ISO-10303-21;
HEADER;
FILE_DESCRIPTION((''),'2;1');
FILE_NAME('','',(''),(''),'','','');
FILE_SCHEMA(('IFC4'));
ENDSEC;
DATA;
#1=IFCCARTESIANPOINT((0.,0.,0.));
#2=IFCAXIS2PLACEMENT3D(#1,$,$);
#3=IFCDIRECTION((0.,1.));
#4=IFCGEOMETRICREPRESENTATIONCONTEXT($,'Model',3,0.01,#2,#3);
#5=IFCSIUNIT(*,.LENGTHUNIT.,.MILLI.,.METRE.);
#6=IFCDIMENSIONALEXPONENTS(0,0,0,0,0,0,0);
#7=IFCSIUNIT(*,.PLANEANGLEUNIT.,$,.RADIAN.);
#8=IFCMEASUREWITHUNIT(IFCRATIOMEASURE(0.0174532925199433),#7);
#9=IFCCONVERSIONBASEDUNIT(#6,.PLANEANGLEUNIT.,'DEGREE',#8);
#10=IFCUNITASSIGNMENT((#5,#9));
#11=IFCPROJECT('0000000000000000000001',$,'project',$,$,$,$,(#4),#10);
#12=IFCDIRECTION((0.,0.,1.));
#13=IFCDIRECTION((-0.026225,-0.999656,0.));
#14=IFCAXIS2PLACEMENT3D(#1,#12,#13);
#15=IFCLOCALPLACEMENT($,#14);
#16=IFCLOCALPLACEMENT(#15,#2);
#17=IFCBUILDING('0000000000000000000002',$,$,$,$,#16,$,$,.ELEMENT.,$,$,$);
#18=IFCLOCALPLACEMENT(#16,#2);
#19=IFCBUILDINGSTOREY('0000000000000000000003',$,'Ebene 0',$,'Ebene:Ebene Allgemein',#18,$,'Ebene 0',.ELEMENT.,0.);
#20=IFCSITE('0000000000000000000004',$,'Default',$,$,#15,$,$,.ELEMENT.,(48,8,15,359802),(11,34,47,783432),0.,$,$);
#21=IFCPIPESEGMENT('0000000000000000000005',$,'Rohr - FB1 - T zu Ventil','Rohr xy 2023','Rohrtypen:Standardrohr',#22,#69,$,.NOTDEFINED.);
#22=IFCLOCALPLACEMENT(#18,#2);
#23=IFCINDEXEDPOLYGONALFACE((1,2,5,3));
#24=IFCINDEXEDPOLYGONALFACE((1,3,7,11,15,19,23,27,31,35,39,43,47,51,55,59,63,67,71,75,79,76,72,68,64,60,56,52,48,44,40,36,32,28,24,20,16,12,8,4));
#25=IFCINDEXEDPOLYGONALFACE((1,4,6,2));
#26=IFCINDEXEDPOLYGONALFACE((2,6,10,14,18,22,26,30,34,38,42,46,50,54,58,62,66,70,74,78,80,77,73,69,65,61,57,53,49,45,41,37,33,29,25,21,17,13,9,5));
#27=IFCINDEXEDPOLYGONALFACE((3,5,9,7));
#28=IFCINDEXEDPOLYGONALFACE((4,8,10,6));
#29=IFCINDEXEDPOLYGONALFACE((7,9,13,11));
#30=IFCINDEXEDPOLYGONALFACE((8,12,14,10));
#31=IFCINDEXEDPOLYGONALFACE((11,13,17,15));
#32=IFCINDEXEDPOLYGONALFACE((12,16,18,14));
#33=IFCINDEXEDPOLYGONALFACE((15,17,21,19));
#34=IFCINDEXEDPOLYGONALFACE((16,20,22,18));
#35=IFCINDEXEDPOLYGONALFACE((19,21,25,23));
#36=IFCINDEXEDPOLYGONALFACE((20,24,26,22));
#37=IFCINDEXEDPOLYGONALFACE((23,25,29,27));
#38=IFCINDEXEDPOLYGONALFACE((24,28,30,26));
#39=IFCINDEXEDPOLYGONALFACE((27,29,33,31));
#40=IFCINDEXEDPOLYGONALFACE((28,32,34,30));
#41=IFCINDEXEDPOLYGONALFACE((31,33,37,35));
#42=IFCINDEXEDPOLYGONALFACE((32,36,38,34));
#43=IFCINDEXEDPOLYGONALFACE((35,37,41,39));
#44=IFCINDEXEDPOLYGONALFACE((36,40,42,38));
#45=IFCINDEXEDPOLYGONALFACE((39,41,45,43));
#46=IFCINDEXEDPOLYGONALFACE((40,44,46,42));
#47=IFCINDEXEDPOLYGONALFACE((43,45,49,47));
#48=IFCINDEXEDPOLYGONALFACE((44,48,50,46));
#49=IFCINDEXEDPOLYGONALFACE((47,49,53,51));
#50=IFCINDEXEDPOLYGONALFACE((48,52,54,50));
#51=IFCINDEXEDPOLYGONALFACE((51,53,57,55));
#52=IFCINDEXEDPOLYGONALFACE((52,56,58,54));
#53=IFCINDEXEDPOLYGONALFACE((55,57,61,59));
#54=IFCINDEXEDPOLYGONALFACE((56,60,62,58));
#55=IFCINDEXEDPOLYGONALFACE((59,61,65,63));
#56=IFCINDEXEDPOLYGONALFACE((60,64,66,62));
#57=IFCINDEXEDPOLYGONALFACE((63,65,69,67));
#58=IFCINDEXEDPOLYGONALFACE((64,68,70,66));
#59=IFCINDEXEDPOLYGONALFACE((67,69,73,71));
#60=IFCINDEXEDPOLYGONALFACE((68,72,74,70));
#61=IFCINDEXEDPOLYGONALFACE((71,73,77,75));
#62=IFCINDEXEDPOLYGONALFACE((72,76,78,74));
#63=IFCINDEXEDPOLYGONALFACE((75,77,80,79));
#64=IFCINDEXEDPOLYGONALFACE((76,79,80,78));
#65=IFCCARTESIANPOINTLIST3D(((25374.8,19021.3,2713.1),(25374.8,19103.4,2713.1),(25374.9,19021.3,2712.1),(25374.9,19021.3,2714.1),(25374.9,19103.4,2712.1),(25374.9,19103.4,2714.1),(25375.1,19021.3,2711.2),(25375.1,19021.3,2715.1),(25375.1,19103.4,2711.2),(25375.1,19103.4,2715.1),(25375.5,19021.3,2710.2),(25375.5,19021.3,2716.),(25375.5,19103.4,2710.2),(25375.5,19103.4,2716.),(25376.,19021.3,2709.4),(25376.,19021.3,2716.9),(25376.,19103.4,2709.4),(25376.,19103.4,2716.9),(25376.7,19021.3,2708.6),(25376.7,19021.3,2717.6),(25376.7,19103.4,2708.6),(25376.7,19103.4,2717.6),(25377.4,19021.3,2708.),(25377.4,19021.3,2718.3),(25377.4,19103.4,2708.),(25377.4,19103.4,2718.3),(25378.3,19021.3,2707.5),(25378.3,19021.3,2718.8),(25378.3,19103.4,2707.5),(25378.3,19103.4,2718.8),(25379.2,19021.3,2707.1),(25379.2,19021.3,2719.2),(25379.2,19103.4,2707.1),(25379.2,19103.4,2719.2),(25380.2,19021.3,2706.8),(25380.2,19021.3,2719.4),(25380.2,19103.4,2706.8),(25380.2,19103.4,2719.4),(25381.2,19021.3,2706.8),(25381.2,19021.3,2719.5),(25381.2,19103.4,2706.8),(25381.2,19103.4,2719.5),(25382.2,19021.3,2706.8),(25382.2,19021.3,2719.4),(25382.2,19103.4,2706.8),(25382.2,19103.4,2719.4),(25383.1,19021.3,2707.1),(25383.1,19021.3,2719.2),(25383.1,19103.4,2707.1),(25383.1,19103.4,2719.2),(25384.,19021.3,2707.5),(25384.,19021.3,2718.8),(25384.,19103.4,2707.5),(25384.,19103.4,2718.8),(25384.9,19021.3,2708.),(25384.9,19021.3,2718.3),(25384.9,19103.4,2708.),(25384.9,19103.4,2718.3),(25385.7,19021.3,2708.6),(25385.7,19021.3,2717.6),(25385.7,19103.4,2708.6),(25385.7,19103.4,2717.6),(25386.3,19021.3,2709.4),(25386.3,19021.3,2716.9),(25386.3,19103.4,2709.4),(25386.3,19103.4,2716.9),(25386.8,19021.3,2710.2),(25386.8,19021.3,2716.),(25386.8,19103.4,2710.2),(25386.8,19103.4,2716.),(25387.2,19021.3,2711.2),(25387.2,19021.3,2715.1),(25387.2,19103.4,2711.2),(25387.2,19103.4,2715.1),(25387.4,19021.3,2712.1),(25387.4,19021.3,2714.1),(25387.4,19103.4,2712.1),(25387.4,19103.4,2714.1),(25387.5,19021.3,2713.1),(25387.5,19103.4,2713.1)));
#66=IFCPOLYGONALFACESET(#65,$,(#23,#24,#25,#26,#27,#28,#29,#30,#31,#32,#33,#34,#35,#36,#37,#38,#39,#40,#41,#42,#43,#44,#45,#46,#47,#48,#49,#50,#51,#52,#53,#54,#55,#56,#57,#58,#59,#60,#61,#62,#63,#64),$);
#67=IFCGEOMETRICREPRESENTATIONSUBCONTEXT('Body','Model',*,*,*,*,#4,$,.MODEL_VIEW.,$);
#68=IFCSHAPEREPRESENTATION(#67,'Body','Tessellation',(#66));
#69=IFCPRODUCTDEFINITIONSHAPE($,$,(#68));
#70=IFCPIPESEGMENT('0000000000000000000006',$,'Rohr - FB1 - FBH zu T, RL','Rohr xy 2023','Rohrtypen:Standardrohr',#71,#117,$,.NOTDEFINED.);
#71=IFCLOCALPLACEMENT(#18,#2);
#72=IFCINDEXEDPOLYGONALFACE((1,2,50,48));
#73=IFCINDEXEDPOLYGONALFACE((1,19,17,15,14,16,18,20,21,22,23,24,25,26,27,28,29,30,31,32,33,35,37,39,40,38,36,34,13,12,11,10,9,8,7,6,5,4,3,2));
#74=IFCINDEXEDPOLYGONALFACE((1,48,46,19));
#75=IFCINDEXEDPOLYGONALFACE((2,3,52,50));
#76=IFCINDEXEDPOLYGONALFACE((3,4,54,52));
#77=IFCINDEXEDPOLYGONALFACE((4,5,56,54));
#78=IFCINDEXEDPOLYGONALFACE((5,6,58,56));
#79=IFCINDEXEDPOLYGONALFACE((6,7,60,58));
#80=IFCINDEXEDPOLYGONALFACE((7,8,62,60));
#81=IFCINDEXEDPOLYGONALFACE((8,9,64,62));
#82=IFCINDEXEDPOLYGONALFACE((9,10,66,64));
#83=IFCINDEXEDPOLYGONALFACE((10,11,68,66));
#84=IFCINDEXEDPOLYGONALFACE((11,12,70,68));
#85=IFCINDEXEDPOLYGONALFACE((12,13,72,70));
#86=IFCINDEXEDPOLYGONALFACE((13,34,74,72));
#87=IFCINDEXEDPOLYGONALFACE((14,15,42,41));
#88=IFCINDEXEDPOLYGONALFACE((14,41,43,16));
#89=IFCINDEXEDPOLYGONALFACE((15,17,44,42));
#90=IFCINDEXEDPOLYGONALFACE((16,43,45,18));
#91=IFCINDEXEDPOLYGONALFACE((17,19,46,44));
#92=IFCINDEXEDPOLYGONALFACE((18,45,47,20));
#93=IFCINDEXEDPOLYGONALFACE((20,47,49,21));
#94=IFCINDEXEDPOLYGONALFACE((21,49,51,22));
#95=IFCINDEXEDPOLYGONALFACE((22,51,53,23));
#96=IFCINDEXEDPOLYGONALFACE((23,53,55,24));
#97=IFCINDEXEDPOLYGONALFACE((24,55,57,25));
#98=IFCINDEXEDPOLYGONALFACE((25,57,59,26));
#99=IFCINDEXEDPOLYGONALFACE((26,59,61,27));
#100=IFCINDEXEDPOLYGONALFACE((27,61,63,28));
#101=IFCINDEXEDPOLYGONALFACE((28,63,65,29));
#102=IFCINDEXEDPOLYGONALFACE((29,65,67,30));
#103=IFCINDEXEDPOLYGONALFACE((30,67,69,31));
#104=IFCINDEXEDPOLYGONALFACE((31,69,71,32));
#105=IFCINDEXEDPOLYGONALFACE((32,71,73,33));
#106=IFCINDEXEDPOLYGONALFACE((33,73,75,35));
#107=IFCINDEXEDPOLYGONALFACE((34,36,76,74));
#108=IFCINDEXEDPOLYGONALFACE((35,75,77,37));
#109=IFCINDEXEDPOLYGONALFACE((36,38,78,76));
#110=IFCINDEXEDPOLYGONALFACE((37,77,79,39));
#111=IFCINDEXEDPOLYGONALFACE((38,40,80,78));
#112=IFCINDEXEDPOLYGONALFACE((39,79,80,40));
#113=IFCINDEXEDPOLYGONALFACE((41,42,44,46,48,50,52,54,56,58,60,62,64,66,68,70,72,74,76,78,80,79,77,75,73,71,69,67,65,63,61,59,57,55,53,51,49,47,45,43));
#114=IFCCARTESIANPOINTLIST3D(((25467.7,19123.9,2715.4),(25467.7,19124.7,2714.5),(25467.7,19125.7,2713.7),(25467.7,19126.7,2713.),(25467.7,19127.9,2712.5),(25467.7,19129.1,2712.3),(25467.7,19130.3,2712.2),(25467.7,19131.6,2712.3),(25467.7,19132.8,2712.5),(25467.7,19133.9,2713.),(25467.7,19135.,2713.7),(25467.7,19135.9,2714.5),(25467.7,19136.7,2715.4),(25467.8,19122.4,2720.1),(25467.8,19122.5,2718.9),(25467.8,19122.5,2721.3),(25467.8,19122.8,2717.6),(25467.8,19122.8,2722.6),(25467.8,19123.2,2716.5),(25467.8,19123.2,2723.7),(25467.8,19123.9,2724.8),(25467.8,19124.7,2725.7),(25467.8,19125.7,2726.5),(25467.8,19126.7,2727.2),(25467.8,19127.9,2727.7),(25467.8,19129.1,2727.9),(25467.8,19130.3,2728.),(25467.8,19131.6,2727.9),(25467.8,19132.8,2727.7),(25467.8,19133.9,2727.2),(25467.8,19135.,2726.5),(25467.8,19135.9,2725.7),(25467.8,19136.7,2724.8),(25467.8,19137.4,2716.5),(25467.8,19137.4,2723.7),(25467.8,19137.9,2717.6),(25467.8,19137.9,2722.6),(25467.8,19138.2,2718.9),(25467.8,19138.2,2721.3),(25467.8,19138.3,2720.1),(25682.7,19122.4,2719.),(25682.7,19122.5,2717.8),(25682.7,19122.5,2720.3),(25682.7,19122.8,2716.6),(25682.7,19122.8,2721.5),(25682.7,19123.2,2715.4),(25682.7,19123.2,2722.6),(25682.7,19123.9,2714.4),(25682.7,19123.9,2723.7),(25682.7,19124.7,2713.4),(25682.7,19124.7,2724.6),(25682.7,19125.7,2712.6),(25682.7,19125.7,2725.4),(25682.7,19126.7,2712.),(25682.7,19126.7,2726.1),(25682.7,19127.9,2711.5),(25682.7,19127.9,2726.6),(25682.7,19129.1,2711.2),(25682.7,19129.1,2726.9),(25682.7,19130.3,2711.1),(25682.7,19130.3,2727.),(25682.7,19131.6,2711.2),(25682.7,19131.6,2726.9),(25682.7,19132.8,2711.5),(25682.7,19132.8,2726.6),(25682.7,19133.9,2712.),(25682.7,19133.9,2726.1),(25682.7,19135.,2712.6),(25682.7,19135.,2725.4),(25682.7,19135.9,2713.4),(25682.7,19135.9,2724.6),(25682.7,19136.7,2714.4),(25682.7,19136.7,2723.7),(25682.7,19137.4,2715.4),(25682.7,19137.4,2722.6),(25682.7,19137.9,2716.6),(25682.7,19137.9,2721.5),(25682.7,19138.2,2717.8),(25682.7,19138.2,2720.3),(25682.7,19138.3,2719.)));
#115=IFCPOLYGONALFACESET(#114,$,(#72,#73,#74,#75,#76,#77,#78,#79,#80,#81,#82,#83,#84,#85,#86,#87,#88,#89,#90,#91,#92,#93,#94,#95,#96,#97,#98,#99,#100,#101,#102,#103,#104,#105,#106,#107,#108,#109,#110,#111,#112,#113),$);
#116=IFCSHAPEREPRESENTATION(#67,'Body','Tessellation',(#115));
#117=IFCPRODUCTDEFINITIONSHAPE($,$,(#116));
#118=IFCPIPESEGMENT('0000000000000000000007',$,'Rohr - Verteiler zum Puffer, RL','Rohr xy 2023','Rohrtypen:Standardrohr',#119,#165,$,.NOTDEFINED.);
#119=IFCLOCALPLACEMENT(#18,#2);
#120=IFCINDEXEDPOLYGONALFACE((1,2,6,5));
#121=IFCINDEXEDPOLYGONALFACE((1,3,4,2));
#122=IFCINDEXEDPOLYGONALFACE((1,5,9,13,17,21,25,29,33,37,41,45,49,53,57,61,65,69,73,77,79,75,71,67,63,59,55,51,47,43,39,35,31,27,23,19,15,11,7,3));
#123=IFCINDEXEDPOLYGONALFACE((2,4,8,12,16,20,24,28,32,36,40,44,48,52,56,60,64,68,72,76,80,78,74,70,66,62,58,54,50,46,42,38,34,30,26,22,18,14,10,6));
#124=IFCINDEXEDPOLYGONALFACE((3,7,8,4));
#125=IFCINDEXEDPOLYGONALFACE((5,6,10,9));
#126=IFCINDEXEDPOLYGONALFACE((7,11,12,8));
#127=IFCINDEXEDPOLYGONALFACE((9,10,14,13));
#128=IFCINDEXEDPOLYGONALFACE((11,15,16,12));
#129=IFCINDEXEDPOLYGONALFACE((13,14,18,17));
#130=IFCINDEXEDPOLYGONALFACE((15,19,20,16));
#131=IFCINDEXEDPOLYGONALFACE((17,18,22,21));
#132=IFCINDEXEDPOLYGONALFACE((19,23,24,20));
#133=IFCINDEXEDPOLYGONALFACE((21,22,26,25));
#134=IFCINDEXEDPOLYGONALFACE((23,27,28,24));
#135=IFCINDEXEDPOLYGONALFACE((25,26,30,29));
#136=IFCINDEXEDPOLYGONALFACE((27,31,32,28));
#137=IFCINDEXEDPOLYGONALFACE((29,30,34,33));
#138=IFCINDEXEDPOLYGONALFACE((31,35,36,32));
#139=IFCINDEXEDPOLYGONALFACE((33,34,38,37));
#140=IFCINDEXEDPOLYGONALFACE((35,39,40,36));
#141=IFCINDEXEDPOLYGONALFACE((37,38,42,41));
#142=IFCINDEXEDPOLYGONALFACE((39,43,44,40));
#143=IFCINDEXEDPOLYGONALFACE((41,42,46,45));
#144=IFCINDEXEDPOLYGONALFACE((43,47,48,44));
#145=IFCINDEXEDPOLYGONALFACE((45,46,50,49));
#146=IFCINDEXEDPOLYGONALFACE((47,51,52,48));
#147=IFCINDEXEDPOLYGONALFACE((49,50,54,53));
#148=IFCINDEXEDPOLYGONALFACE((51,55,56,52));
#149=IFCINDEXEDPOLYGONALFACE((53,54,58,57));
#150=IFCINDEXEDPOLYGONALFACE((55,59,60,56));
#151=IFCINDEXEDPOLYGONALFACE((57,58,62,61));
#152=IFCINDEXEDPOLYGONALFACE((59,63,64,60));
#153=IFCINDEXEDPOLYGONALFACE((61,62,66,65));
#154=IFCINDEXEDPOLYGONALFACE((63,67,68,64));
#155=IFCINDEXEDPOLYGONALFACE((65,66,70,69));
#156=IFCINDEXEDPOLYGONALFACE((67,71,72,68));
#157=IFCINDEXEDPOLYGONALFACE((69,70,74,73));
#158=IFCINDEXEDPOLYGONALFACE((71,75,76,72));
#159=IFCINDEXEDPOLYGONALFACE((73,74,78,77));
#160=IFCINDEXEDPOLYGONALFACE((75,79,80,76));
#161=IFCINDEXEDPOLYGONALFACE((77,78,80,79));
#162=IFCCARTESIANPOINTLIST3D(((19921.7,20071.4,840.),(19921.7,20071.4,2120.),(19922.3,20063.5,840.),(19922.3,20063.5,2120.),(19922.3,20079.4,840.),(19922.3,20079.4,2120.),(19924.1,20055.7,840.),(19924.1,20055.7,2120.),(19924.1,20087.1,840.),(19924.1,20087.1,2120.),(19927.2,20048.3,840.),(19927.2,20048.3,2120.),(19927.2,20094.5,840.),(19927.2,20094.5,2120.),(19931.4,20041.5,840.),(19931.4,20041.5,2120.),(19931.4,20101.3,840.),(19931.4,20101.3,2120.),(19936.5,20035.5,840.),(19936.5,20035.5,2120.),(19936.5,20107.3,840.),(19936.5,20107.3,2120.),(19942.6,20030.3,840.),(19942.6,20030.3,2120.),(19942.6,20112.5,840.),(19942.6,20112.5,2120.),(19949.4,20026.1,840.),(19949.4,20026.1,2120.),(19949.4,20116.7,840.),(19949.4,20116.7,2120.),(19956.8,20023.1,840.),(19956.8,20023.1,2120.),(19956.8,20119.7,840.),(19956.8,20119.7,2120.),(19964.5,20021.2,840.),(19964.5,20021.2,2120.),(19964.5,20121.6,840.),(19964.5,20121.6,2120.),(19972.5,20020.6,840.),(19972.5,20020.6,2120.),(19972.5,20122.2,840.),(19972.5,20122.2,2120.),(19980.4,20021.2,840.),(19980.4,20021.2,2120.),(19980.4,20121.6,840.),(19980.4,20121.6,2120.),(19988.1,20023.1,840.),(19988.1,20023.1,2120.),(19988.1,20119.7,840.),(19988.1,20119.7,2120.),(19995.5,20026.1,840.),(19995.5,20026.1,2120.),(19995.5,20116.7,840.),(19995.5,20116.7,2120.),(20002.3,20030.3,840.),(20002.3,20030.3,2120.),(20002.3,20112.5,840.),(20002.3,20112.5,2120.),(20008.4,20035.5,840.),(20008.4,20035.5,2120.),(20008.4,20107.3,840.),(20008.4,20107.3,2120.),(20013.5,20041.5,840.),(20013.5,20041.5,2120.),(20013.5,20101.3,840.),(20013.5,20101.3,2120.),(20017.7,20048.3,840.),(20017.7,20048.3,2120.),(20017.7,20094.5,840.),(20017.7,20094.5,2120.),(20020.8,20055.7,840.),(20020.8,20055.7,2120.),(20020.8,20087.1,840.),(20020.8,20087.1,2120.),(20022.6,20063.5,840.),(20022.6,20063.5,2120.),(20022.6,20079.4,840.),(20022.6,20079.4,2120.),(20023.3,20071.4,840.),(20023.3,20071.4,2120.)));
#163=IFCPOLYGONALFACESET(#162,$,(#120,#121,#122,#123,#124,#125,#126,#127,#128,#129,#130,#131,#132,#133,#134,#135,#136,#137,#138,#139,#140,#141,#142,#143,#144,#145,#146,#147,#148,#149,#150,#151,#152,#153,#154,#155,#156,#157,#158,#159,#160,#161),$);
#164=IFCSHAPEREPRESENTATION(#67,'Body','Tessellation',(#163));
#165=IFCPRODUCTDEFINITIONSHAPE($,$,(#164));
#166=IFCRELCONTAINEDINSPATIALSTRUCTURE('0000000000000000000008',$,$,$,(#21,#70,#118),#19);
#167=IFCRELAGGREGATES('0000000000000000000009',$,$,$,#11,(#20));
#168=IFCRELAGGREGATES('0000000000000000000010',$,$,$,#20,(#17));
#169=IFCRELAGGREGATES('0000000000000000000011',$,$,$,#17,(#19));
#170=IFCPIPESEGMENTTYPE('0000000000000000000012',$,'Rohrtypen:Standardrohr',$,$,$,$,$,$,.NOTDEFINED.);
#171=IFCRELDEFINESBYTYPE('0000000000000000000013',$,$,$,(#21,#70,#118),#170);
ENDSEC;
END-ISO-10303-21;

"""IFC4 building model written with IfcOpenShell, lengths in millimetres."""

from ifc_helpers import new_model, entity, si_unit, converted_unit, direction, frame, origin, place, context, subcontext, project, spatial, indexed_curve, outline, extrude, type_object, element, save


model = new_model("IFC4")

# Units and contexts
model_context = context("Model", 3, precision=0.01, world=origin(), true_north=direction((0.0, 1.0)))
body_context = subcontext(model_context, "Body", "Model", "MODEL_VIEW")
ifc_project = project(units=[si_unit("LENGTHUNIT", "METRE", prefix="MILLI"), converted_unit("PLANEANGLEUNIT", "DEGREE", entity("IfcRatioMeasure", 0.0174532925199433), si_unit("PLANEANGLEUNIT", "RADIAN"), dimensions=[0, 0, 0, 0, 0, 0, 0])], contexts=[model_context])

# Site, building, storey
site_placement = place(None, frame((0.0, 0.0, 0.0), z_axis=(0.0, 0.0, 1.0), x_axis=(-0.026225, -0.999656, 0.0)))
site = spatial("IfcSite", under=ifc_project, at=site_placement, Name="Default", CompositionType="ELEMENT", RefLatitude=(48, 8, 15, 359802), RefLongitude=(11, 34, 47, 783432), RefElevation=0.0)
building_placement = place(site_placement, origin())
building = spatial("IfcBuilding", under=site, at=building_placement, CompositionType="ELEMENT")
storey_placement = place(building_placement, origin())
storey = spatial("IfcBuildingStorey", under=building, at=storey_placement, Name="Ebene 0", ObjectType="Ebene:Ebene Allgemein", LongName="Ebene 0", CompositionType="ELEMENT", Elevation=0.0)

# Pipe segments
pipe_segment_type = type_object("IfcPipeSegmentType", Name="Rohrtypen:Standardrohr", PredefinedType="NOTDEFINED")
pipe_segment_1_placement = place(storey_placement, origin())
element("IfcPipeSegment", 1, at=pipe_segment_1_placement, inside=storey, type_object=pipe_segment_type, Name="Rohr - FB1 - T zu Ventil", Description="Rohr xy 2023", ObjectType="Rohrtypen:Standardrohr", PredefinedType="NOTDEFINED", context=body_context, shape_type="SweptSolid", body=[
    extrude(outline(indexed_curve([(6.3, 0.0), (6.3, 1.0), (6.0, 2.0), (5.7, 2.9), (5.1, 3.7), (4.5, 4.5), (3.7, 5.1), (2.9, 5.7), (2.0, 6.0), (1.0, 6.3), (0.0, 6.4), (-1.0, 6.3), (-2.0, 6.0), (-2.9, 5.7), (-3.7, 5.1), (-4.5, 4.5), (-5.1, 3.7), (-5.7, 2.9), (-6.0, 2.0), (-6.3, 1.0), (-6.3, 0.0), (-6.3, -1.0), (-6.0, -2.0), (-5.7, -2.9), (-5.1, -3.7), (-4.5, -4.5), (-3.7, -5.1), (-2.9, -5.7), (-2.0, -6.0), (-1.0, -6.3), (0.0, -6.4), (1.0, -6.3), (2.0, -6.0), (2.9, -5.7), (3.7, -5.1), (4.5, -4.5), (5.1, -3.7), (5.7, -2.9), (6.0, -2.0), (6.3, -1.0), (6.3, 0.0)], self_intersect=False)), frame((25381.2, 19021.3, 2713.1), z_axis=(0.0, 1.0, 0.0), x_axis=(-1.0, 0.0, 0.0)), (0.0, 0.0, 1.0), 82.2),
])
pipe_segment_2_placement = place(storey_placement, origin())
element("IfcPipeSegment", 2, at=pipe_segment_2_placement, inside=storey, type_object=pipe_segment_type, Name="Rohr - FB1 - FBH zu T, RL", Description="Rohr xy 2023", ObjectType="Rohrtypen:Standardrohr", PredefinedType="NOTDEFINED", context=body_context, shape_type="SweptSolid", body=[
    extrude(outline(indexed_curve([(7.9, 0.0), (7.8, 1.2), (7.6, 2.5), (7.1, 3.6), (6.4, 4.7), (5.6, 5.6), (4.7, 6.4), (3.6, 7.1), (2.5, 7.6), (1.2, 7.8), (0.0, 7.9), (-1.2, 7.8), (-2.5, 7.6), (-3.6, 7.1), (-4.7, 6.4), (-5.6, 5.6), (-6.4, 4.7), (-7.1, 3.6), (-7.6, 2.5), (-7.8, 1.2), (-7.9, 0.0), (-7.8, -1.2), (-7.6, -2.5), (-7.1, -3.6), (-6.4, -4.7), (-5.6, -5.6), (-4.7, -6.4), (-3.6, -7.1), (-2.5, -7.6), (-1.2, -7.8), (0.0, -7.9), (1.2, -7.8), (2.5, -7.6), (3.6, -7.1), (4.7, -6.4), (5.6, -5.6), (6.4, -4.7), (7.1, -3.6), (7.6, -2.5), (7.8, -1.2), (7.9, 0.0)], self_intersect=False)), frame((25682.7, 19130.3, 2719.0), z_axis=(-0.999988, 0.0, 0.005), x_axis=(0.0, 1.0, 0.0)), (0.0, 0.0, 1.0), 214.9),
])
pipe_segment_3_placement = place(storey_placement, origin())
element("IfcPipeSegment", 3, at=pipe_segment_3_placement, inside=storey, type_object=pipe_segment_type, Name="Rohr - Verteiler zum Puffer, RL", Description="Rohr xy 2023", ObjectType="Rohrtypen:Standardrohr", PredefinedType="NOTDEFINED", context=body_context, shape_type="SweptSolid", body=[
    extrude(outline(indexed_curve([(50.8, 0.0), (50.2, 7.9), (48.3, 15.7), (45.3, 23.1), (41.1, 29.9), (35.9, 35.9), (29.9, 41.1), (23.1, 45.3), (15.7, 48.3), (7.9, 50.2), (0.0, 50.8), (-7.9, 50.2), (-15.7, 48.3), (-23.1, 45.3), (-29.9, 41.1), (-35.9, 35.9), (-41.1, 29.9), (-45.3, 23.1), (-48.3, 15.7), (-50.2, 7.9), (-50.8, 0.0), (-50.2, -7.9), (-48.3, -15.7), (-45.3, -23.1), (-41.1, -29.9), (-35.9, -35.9), (-29.9, -41.1), (-23.1, -45.3), (-15.7, -48.3), (-7.9, -50.2), (0.0, -50.8), (7.9, -50.2), (15.7, -48.3), (23.1, -45.3), (29.9, -41.1), (35.9, -35.9), (41.1, -29.9), (45.3, -23.1), (48.3, -15.7), (50.2, -7.9), (50.8, 0.0)], self_intersect=False)), frame((19972.5, 20071.4, 840.0), z_axis=(0.0, 0.0, 1.0), x_axis=(-1.0, 0.0, 0.0)), (0.0, 0.0, 1.0), 1280.0),
])

save(model, "model.ifc")
